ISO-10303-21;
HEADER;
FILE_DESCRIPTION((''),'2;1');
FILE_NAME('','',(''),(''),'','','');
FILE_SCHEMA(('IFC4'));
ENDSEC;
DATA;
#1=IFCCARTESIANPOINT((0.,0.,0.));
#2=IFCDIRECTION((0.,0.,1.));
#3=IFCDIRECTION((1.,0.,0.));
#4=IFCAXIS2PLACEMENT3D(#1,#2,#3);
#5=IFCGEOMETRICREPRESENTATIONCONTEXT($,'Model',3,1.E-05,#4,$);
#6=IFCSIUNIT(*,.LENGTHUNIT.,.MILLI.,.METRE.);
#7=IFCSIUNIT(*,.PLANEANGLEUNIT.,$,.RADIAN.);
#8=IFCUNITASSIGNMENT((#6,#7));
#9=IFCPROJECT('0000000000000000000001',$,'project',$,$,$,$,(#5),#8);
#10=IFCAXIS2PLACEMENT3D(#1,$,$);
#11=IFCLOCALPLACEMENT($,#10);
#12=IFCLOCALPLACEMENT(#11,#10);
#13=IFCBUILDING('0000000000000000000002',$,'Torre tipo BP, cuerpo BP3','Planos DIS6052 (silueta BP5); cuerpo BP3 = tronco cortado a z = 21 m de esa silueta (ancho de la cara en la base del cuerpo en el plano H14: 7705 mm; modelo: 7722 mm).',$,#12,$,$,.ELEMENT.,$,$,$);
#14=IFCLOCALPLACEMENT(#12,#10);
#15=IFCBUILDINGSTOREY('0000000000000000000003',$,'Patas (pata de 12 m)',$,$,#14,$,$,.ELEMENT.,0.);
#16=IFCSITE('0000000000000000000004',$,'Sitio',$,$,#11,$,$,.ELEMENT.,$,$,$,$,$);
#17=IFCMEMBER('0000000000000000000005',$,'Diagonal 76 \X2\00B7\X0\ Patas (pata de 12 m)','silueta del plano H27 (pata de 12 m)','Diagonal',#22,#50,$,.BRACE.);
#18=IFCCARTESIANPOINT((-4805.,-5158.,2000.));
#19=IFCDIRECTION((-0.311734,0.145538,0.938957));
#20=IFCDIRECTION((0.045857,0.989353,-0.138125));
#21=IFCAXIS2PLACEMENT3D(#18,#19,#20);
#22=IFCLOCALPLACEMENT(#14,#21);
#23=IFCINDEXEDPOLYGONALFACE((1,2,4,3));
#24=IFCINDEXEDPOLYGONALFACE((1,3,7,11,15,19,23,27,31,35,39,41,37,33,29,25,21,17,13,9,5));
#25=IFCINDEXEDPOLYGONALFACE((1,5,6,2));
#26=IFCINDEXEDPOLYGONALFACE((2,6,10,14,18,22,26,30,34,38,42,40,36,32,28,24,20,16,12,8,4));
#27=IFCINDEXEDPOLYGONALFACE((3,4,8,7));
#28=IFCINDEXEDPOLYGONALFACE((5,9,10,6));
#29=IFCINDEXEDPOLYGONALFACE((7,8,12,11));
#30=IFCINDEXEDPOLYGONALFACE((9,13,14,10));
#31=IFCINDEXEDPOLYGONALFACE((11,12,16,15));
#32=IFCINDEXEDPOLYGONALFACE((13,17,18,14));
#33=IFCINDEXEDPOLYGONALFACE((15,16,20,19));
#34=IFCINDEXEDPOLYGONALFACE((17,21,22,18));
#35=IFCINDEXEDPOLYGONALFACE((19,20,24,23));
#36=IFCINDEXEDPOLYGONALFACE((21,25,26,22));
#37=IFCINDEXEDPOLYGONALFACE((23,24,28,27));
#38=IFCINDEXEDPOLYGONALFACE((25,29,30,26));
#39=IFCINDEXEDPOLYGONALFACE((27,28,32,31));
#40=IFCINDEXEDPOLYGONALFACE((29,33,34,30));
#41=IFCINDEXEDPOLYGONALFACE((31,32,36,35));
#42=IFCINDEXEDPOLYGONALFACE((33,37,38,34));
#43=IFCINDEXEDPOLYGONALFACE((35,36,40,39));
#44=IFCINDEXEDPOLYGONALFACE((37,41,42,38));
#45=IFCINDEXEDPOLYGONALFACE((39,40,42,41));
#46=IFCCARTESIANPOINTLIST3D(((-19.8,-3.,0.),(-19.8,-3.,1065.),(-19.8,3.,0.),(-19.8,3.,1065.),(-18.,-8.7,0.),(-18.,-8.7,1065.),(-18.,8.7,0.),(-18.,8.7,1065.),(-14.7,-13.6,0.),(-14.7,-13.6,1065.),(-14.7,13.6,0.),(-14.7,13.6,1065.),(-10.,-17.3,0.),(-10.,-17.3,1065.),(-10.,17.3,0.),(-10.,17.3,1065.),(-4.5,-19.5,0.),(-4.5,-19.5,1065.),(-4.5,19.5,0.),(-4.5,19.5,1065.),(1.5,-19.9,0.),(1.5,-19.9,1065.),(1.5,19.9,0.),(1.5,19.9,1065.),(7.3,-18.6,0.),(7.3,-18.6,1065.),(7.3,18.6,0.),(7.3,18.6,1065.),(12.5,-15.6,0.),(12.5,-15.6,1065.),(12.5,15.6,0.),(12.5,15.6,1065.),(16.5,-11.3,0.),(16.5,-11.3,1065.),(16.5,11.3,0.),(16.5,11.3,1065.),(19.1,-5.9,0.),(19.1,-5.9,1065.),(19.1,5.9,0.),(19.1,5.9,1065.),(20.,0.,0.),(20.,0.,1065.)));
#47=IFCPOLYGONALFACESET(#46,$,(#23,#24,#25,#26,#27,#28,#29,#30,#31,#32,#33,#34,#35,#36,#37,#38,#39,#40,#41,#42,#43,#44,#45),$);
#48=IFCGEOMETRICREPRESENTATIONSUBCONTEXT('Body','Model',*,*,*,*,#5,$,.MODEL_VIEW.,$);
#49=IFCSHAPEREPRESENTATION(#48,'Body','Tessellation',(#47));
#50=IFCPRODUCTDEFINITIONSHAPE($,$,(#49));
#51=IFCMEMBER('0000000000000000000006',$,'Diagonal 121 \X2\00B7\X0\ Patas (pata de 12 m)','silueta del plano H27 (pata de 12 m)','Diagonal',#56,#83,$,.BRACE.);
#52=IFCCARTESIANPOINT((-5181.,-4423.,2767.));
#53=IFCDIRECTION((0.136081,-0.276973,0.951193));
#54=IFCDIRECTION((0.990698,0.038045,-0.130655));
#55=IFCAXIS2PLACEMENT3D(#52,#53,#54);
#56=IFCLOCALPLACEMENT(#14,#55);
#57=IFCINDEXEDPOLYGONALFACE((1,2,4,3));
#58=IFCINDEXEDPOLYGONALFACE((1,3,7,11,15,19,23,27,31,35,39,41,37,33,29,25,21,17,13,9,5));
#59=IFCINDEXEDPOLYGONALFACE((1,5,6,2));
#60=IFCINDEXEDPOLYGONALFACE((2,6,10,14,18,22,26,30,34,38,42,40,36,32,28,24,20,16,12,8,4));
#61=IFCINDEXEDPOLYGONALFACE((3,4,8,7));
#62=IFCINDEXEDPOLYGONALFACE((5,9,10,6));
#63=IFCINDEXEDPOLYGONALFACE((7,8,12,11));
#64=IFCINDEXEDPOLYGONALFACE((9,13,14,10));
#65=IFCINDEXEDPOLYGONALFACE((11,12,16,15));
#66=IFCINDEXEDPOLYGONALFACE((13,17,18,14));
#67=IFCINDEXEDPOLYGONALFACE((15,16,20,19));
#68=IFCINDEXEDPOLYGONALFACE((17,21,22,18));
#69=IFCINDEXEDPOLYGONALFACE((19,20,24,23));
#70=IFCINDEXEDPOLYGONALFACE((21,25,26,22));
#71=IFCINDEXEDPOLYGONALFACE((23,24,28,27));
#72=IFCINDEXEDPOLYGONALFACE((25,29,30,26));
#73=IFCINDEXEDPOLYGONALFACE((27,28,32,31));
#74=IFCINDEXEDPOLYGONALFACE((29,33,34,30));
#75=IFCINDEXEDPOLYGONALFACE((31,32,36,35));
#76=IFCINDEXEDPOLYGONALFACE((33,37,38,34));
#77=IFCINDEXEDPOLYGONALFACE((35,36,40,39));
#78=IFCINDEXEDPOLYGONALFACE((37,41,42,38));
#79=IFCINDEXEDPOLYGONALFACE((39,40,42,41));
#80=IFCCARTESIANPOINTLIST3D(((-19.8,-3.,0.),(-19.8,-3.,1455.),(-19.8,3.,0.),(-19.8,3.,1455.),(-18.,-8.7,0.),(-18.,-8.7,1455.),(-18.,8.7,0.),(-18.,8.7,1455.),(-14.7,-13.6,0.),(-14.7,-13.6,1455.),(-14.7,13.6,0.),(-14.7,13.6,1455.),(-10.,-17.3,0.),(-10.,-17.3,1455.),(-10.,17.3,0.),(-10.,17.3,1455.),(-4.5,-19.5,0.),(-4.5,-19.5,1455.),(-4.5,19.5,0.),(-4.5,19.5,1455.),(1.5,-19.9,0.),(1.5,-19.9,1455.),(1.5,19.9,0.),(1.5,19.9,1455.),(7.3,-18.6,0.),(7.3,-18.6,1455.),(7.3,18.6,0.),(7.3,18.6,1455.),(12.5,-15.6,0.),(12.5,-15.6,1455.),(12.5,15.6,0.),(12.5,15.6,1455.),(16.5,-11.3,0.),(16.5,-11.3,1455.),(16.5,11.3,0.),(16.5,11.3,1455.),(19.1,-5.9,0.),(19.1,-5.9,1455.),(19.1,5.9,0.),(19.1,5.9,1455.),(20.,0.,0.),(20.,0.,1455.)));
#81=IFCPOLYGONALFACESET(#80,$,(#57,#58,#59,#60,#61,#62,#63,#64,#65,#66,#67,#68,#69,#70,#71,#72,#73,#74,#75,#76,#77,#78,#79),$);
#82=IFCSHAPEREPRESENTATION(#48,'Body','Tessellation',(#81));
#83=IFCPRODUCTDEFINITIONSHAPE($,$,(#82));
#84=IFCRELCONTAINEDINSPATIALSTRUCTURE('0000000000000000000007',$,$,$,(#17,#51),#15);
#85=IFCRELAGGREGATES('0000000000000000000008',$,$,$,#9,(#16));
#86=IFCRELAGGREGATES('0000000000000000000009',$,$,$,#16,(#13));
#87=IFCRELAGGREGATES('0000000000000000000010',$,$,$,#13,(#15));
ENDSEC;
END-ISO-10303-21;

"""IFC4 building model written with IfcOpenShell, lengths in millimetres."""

from ifc_helpers import new_model, si_unit, frame, origin, origin_with_axes, place, context, subcontext, project, spatial, circle, extrude, element, save


model = new_model("IFC4")

# Units and contexts
model_context = context("Model", 3, precision=1e-05, world=origin_with_axes())
body_context = subcontext(model_context, "Body", "Model", "MODEL_VIEW")
ifc_project = project(units=[si_unit("LENGTHUNIT", "METRE", prefix="MILLI"), si_unit("PLANEANGLEUNIT", "RADIAN")], contexts=[model_context])

# Site, building, storey
site_placement = place(None, origin())
site = spatial("IfcSite", under=ifc_project, at=site_placement, Name="Sitio", CompositionType="ELEMENT")
building_placement = place(site_placement, origin())
building = spatial("IfcBuilding", under=site, at=building_placement, Name="Torre tipo BP, cuerpo BP3", Description="Planos DIS6052 (silueta BP5); cuerpo BP3 = tronco cortado a z = 21 m de esa silueta (ancho de la cara en la base del cuerpo en el plano H14: 7705 mm; modelo: 7722 mm).", CompositionType="ELEMENT")
storey_placement = place(building_placement, origin())
storey = spatial("IfcBuildingStorey", under=building, at=storey_placement, Name="Patas (pata de 12 m)", CompositionType="ELEMENT", Elevation=0.0)

# Members
member_1_placement = place(storey_placement, frame((-4805.0, -5158.0, 2000.0), z_axis=(-0.311734, 0.145538, 0.938957), x_axis=(0.045857, 0.989353, -0.138125)))
element("IfcMember", 1, at=member_1_placement, inside=storey, Name="Diagonal 76 · Patas (pata de 12 m)", Description="silueta del plano H27 (pata de 12 m)", ObjectType="Diagonal", PredefinedType="BRACE", context=body_context, shape_type="SweptSolid", body=[
    extrude(circle(Radius=20.0), None, (0.0, 0.0, 1.0), 1065.0),
])
member_2_placement = place(storey_placement, frame((-5181.0, -4423.0, 2767.0), z_axis=(0.136081, -0.276973, 0.951193), x_axis=(0.990698, 0.038045, -0.130655)))
element("IfcMember", 2, at=member_2_placement, inside=storey, Name="Diagonal 121 · Patas (pata de 12 m)", Description="silueta del plano H27 (pata de 12 m)", ObjectType="Diagonal", PredefinedType="BRACE", context=body_context, shape_type="SweptSolid", body=[
    extrude(circle(Radius=20.0), None, (0.0, 0.0, 1.0), 1455.0),
])

save(model, "model.ifc")
